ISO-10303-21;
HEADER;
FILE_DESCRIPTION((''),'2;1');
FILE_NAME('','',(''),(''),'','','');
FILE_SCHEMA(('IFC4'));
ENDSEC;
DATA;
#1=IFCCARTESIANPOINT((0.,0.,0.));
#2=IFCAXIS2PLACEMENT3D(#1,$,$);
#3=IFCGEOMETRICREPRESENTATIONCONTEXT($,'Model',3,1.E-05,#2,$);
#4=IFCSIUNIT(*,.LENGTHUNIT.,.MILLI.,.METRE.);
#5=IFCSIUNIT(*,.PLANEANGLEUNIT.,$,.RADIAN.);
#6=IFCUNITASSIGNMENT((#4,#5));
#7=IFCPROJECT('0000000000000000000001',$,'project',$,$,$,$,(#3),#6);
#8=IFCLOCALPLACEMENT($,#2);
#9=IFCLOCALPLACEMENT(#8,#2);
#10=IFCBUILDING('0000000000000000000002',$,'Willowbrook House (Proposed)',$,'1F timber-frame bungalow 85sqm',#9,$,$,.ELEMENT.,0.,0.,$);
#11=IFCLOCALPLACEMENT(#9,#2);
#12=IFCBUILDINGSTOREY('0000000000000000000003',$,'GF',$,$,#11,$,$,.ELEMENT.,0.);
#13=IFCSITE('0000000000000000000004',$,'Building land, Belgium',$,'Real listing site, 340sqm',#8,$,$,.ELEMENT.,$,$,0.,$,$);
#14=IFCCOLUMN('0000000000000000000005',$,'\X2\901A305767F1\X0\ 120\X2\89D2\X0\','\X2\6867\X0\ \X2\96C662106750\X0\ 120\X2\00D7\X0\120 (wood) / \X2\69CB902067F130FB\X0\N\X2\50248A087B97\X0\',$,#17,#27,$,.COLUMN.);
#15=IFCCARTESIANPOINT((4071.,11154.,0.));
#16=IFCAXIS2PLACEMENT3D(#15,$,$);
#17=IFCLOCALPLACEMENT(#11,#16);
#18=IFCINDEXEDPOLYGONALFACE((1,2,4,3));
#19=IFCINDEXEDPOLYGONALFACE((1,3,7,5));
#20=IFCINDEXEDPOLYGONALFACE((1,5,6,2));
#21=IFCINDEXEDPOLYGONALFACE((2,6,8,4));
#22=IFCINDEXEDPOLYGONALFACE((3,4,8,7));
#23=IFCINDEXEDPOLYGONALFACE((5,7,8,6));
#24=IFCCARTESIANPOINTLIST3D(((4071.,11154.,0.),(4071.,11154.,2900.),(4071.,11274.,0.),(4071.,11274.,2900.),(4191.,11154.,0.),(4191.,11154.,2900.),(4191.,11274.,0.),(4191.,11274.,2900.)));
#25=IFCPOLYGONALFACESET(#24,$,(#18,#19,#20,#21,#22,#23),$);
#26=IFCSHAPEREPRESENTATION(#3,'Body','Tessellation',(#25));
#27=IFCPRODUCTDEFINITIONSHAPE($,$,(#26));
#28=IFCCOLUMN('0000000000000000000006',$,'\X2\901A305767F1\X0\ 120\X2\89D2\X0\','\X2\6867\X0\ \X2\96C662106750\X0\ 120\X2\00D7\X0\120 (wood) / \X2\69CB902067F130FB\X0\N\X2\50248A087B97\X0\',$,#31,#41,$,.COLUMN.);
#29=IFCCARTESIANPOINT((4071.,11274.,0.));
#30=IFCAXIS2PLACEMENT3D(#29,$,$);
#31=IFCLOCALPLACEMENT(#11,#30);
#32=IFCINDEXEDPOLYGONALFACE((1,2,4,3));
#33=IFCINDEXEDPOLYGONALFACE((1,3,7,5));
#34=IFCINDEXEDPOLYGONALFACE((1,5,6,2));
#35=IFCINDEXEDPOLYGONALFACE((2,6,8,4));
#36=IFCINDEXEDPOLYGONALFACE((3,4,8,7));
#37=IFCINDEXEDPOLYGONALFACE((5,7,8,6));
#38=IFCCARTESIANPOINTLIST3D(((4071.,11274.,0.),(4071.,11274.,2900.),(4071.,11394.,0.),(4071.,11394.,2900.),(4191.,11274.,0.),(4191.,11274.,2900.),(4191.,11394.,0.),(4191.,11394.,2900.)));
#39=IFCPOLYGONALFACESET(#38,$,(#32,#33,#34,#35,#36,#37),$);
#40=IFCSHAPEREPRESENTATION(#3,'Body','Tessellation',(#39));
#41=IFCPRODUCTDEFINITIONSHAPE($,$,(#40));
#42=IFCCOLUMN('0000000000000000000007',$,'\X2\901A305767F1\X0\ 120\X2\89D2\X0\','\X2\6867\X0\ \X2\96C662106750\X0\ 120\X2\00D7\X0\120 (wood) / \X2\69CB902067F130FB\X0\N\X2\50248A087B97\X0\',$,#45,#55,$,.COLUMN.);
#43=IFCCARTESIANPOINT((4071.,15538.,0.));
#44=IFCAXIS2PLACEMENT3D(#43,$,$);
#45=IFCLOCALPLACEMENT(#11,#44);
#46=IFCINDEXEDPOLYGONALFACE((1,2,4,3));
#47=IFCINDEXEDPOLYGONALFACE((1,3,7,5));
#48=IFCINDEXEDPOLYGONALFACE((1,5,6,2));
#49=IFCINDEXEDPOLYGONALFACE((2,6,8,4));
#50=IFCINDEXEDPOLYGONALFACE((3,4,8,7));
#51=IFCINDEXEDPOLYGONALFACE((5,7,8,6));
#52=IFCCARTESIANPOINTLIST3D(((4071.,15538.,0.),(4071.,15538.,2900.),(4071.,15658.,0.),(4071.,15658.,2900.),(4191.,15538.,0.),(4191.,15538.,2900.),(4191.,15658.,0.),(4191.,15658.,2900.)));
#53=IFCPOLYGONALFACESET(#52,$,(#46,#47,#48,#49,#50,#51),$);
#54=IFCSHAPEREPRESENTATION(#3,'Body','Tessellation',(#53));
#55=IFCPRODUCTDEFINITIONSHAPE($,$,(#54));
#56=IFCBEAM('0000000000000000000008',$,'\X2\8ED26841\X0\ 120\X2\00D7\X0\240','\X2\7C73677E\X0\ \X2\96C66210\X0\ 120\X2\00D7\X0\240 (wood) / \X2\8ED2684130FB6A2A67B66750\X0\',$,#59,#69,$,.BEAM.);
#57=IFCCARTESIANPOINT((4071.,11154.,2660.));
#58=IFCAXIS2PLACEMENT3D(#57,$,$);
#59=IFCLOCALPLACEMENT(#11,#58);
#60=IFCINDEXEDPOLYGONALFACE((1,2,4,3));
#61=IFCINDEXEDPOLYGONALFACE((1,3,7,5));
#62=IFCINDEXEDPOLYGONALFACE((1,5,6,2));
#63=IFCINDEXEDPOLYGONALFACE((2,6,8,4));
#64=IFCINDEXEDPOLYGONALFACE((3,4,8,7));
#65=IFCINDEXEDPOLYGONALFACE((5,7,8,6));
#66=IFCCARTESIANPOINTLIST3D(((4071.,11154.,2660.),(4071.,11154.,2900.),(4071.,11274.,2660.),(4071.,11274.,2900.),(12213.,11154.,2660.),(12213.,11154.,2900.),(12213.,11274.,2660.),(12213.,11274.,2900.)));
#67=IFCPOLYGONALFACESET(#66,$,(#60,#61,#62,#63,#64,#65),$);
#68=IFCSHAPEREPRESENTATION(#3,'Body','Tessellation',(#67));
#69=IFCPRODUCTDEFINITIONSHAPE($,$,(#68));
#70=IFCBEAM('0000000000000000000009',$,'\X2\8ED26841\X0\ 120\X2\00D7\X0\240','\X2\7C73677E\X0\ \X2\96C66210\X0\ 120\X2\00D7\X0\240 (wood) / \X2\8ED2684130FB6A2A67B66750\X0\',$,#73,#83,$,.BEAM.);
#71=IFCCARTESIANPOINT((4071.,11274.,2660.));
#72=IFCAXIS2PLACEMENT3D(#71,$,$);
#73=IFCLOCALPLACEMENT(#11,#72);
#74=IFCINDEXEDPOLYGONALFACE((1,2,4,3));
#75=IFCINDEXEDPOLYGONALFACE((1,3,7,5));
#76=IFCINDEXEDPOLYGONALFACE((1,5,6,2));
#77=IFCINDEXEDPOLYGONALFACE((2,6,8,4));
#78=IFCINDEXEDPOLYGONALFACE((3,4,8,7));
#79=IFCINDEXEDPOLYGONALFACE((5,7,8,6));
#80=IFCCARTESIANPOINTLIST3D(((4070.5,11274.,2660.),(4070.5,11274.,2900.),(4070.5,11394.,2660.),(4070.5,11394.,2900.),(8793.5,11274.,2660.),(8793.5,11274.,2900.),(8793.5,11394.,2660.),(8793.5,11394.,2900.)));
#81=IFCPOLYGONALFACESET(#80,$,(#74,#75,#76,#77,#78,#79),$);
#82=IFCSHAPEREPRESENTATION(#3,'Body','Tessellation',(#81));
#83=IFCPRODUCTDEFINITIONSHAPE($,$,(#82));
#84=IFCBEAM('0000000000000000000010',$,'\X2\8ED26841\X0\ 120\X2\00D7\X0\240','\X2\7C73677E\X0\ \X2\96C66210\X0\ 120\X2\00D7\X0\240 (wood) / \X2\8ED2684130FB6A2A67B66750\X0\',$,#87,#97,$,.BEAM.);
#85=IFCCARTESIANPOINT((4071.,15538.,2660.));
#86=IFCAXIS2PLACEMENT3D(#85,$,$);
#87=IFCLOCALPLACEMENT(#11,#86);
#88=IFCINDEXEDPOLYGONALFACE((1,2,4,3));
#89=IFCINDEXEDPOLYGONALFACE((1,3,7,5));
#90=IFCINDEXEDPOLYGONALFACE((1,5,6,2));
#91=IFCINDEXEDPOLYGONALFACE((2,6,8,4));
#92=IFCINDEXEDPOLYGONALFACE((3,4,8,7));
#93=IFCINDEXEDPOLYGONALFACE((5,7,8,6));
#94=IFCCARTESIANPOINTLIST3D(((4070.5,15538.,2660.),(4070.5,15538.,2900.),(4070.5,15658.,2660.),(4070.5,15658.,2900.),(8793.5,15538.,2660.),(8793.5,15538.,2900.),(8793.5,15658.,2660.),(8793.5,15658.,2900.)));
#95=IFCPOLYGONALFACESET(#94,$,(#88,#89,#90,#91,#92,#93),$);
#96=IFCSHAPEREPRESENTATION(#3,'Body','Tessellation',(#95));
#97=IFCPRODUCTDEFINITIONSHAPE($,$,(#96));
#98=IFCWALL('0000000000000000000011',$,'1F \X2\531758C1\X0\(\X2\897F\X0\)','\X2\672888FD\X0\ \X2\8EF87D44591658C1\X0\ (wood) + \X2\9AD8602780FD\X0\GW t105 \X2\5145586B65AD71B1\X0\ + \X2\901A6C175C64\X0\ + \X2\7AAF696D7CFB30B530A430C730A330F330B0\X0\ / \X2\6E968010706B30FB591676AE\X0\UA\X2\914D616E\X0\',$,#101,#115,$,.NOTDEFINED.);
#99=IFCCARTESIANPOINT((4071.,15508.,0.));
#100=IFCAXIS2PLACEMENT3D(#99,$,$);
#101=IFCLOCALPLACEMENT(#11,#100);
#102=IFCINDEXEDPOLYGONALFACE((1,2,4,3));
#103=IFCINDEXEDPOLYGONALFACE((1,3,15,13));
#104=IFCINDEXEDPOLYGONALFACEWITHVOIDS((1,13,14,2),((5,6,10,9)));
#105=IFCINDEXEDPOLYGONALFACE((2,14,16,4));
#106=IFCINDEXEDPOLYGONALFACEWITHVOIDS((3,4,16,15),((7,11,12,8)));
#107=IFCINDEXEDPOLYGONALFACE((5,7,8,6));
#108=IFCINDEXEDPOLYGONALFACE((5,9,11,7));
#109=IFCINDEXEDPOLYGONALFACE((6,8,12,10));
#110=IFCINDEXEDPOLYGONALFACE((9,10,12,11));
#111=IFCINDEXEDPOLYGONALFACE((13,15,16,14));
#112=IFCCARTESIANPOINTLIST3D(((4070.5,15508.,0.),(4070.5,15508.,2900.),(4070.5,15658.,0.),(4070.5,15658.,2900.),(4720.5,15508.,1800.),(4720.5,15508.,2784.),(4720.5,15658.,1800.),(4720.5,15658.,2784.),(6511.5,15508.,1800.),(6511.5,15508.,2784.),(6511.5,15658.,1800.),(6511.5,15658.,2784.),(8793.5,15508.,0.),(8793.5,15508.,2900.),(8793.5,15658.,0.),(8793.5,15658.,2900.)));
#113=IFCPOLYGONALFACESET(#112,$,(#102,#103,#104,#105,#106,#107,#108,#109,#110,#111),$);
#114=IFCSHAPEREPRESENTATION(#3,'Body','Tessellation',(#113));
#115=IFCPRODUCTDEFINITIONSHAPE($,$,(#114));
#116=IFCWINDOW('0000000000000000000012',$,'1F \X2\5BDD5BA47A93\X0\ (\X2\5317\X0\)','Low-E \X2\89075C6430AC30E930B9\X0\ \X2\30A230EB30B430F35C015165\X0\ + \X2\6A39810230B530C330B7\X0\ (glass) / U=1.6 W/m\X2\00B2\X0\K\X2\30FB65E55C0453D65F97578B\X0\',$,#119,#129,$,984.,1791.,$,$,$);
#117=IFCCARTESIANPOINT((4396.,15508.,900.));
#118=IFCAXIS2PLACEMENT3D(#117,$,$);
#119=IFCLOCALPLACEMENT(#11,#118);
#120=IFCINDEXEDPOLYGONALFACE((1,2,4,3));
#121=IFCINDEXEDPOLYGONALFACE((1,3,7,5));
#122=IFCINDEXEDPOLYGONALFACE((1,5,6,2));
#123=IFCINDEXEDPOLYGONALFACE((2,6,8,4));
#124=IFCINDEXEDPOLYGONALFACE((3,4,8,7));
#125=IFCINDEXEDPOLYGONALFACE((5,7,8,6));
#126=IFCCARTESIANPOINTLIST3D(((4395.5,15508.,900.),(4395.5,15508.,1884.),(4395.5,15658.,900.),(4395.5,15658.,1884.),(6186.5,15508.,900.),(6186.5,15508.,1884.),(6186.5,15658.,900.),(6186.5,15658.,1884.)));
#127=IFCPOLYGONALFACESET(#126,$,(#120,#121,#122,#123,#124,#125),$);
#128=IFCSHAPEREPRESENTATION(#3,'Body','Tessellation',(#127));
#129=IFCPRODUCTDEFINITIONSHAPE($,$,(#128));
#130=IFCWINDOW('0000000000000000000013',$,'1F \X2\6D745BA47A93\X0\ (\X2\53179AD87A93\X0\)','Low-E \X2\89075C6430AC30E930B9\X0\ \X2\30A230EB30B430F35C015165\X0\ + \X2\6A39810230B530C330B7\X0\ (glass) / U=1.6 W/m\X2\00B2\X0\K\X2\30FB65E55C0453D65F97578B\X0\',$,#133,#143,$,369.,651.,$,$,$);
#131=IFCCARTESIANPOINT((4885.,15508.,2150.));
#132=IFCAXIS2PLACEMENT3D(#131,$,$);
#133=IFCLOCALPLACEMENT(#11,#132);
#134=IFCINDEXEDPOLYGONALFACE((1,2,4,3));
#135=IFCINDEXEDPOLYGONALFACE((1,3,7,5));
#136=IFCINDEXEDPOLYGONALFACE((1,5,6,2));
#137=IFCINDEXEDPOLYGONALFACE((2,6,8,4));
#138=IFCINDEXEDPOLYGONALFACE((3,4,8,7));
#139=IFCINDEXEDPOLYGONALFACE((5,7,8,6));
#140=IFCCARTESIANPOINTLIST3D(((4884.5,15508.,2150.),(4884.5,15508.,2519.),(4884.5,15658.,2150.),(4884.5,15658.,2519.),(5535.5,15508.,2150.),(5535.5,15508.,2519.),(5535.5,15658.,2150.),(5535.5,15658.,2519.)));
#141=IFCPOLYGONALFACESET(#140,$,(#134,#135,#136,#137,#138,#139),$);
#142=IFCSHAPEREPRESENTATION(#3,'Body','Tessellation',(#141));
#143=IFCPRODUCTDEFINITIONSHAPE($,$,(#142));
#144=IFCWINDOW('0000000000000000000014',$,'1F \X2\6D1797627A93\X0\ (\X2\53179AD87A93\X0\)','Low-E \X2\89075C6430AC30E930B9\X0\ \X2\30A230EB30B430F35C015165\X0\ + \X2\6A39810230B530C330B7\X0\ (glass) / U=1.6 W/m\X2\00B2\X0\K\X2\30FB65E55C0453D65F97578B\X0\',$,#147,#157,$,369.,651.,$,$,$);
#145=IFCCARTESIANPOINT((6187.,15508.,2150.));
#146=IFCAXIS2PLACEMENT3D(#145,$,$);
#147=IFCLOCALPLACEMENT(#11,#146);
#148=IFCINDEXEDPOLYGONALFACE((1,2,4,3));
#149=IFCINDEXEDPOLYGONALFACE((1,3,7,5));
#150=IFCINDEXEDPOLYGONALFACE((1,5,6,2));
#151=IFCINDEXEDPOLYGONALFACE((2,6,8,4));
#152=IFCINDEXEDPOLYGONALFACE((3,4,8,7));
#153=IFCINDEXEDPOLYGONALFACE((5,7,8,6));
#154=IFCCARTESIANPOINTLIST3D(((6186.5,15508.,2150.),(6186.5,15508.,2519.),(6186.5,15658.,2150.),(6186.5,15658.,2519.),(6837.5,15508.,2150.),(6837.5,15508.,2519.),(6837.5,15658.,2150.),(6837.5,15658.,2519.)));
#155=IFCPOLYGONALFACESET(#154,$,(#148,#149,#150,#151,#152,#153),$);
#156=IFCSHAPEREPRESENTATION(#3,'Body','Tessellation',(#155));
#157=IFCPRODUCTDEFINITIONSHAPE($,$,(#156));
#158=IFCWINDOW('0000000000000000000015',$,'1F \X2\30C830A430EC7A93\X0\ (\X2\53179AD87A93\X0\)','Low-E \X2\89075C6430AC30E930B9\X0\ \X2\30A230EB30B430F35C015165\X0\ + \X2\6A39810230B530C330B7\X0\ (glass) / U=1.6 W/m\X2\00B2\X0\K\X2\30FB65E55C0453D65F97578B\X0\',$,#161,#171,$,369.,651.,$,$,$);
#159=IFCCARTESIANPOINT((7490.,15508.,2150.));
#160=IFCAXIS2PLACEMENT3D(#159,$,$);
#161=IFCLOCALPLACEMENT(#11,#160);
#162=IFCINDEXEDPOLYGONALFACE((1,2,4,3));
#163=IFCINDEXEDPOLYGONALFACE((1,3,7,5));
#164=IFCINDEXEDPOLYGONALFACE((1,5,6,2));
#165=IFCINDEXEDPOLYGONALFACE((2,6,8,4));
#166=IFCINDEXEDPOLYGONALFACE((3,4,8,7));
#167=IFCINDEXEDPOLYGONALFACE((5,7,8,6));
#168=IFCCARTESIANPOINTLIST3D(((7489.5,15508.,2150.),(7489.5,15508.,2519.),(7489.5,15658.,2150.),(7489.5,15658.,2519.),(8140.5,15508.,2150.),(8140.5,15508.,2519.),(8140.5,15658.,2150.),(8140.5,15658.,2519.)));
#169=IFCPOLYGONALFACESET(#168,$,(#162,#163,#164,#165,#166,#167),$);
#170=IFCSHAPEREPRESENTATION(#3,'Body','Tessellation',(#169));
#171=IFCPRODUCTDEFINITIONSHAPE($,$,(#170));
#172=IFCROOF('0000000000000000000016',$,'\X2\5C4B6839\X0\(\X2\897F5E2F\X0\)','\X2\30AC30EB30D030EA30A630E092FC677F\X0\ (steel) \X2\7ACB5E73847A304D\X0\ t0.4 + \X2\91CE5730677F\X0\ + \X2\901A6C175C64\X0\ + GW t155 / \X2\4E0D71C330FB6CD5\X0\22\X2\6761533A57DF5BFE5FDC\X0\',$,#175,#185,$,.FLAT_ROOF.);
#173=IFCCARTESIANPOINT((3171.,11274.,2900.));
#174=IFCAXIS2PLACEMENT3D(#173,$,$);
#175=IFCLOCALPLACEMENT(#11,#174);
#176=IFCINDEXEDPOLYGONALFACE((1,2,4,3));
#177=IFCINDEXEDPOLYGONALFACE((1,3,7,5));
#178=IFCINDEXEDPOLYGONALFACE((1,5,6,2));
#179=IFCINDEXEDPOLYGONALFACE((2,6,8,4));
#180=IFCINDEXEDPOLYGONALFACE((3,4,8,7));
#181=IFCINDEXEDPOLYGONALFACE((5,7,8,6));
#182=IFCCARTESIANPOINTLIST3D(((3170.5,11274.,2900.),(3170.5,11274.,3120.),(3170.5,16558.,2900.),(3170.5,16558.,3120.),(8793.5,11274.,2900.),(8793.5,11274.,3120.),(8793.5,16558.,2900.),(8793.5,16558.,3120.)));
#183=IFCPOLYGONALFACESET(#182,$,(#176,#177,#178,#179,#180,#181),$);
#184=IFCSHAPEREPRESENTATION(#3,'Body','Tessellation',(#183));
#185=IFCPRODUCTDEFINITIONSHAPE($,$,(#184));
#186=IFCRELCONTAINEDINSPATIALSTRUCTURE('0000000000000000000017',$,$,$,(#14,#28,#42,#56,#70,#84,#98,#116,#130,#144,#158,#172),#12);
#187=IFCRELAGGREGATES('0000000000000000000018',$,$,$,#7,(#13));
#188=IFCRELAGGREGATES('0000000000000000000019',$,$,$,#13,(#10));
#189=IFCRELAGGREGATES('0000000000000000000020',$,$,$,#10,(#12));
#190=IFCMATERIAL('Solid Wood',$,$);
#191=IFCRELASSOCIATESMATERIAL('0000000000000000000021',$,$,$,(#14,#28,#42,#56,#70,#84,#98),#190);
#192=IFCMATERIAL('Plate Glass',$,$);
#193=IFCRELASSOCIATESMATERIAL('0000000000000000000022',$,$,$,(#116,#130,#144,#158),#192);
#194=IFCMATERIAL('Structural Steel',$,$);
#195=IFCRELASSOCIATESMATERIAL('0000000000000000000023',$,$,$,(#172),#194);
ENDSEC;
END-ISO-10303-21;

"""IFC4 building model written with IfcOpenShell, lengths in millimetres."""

from ifc_helpers import new_model, si_unit, frame, frame_2d, origin, place, context, project, spatial, rectangle, extrude, material, element, fill, save


model = new_model("IFC4")

# Units and contexts
model_context = context("Model", 3, precision=1e-05, world=origin())
ifc_project = project(units=[si_unit("LENGTHUNIT", "METRE", prefix="MILLI"), si_unit("PLANEANGLEUNIT", "RADIAN")], contexts=[model_context])

# Site, building, storey
site_placement = place(None, origin())
site = spatial("IfcSite", under=ifc_project, at=site_placement, Name="Building land, Belgium", ObjectType="Real listing site, 340sqm", CompositionType="ELEMENT", RefElevation=0.0)
building_placement = place(site_placement, origin())
building = spatial("IfcBuilding", under=site, at=building_placement, Name="Willowbrook House (Proposed)", ObjectType="1F timber-frame bungalow 85sqm", CompositionType="ELEMENT", ElevationOfRefHeight=0.0, ElevationOfTerrain=0.0)
storey_placement = place(building_placement, origin())
storey = spatial("IfcBuildingStorey", under=building, at=storey_placement, Name="GF", CompositionType="ELEMENT", Elevation=0.0)

# Columns
ifc_material_1 = material(Name="Solid Wood")
column_1_placement = place(storey_placement, frame((4071.0, 11154.0, 0.0)))
element("IfcColumn", 1, at=column_1_placement, inside=storey, material=ifc_material_1, Name="通し柱 120角", Description="桧 集成材 120×120 (wood) / 構造柱・N値計算", PredefinedType="COLUMN", context=model_context, shape_type="SweptSolid", body=[
    extrude(rectangle(XDim=120.0, YDim=120.0, at=frame_2d((60.0, 60.0))), frame((4071.0, 11154.0, 0.0)), (0.0, 0.0, 1.0), 2900.0),
])
column_2_placement = place(storey_placement, frame((4071.0, 11274.0, 0.0)))
element("IfcColumn", 2, at=column_2_placement, inside=storey, material=ifc_material_1, Name="通し柱 120角", Description="桧 集成材 120×120 (wood) / 構造柱・N値計算", PredefinedType="COLUMN", context=model_context, shape_type="SweptSolid", body=[
    extrude(rectangle(XDim=120.0, YDim=120.0, at=frame_2d((60.0, 60.0))), frame((4071.0, 11274.0, 0.0)), (0.0, 0.0, 1.0), 2900.0),
])
column_3_placement = place(storey_placement, frame((4071.0, 15538.0, 0.0)))
element("IfcColumn", 3, at=column_3_placement, inside=storey, material=ifc_material_1, Name="通し柱 120角", Description="桧 集成材 120×120 (wood) / 構造柱・N値計算", PredefinedType="COLUMN", context=model_context, shape_type="SweptSolid", body=[
    extrude(rectangle(XDim=120.0, YDim=120.0, at=frame_2d((60.0, 60.0))), frame((4071.0, 15538.0, 0.0)), (0.0, 0.0, 1.0), 2900.0),
])

# Beams
beam_1_placement = place(storey_placement, frame((4071.0, 11154.0, 2660.0)))
element("IfcBeam", 4, at=beam_1_placement, inside=storey, material=ifc_material_1, Name="軒桁 120×240", Description="米松 集成 120×240 (wood) / 軒桁・横架材", PredefinedType="BEAM", context=model_context, shape_type="SweptSolid", body=[
    extrude(rectangle(XDim=8142.0, YDim=120.0, at=frame_2d((4071.0, 60.0))), frame((4071.0, 11154.0, 2660.0)), (0.0, 0.0, 1.0), 240.0),
])
beam_2_placement = place(storey_placement, frame((4071.0, 11274.0, 2660.0)))
element("IfcBeam", 5, at=beam_2_placement, inside=storey, material=ifc_material_1, Name="軒桁 120×240", Description="米松 集成 120×240 (wood) / 軒桁・横架材", PredefinedType="BEAM", context=model_context, shape_type="SweptSolid", body=[
    extrude(rectangle(XDim=4723.0, YDim=120.0, at=frame_2d((2361.0, 60.0))), frame((4071.0, 11274.0, 2660.0)), (0.0, 0.0, 1.0), 240.0),
])
beam_3_placement = place(storey_placement, frame((4071.0, 15538.0, 2660.0)))
element("IfcBeam", 6, at=beam_3_placement, inside=storey, material=ifc_material_1, Name="軒桁 120×240", Description="米松 集成 120×240 (wood) / 軒桁・横架材", PredefinedType="BEAM", context=model_context, shape_type="SweptSolid", body=[
    extrude(rectangle(XDim=4723.0, YDim=120.0, at=frame_2d((2361.0, 60.0))), frame((4071.0, 15538.0, 2660.0)), (0.0, 0.0, 1.0), 240.0),
])

# Wall, openings, windows
wall_1_placement = place(storey_placement, frame((4071.0, 15508.0, 0.0)))
wall_1 = element("IfcWall", 7, at=wall_1_placement, inside=storey, material=ifc_material_1, Name="1F 北壁(西)", Description="木製 軸組外壁 (wood) + 高性能GW t105 充填断熱 + 通気層 + 窯業系サイディング / 準耐火・外皮UA配慮", PredefinedType="NOTDEFINED", context=model_context, shape_type="SweptSolid", body=[
    extrude(rectangle(XDim=4723.0, YDim=150.0, at=frame_2d((2361.0, 75.0))), frame((4071.0, 15508.0, 0.0)), (0.0, 0.0, 1.0), 2900.0),
])
opening_1_placement = place(storey_placement, frame((4396.0, 15508.0, 900.0)))
opening_1 = element("IfcOpeningElement", 8, at=opening_1_placement, cuts=wall_1, PredefinedType="NOTDEFINED", context=model_context, shape_type="SweptSolid", body=[
    extrude(rectangle(XDim=1791.0, YDim=150.0, at=frame_2d((895.0, 75.0))), frame((4396.0, 15508.0, 900.0)), (0.0, 0.0, 1.0), 984.0),
])
opening_2_placement = place(storey_placement, frame((4885.0, 15508.0, 2150.0)))
opening_2 = element("IfcOpeningElement", 9, at=opening_2_placement, cuts=wall_1, PredefinedType="NOTDEFINED", context=model_context, shape_type="SweptSolid", body=[
    extrude(rectangle(XDim=651.0, YDim=150.0, at=frame_2d((325.0, 75.0))), frame((4885.0, 15508.0, 2150.0)), (0.0, 0.0, 1.0), 369.0),
])
opening_3_placement = place(storey_placement, frame((6187.0, 15508.0, 2150.0)))
opening_3 = element("IfcOpeningElement", 10, at=opening_3_placement, cuts=wall_1, PredefinedType="NOTDEFINED", context=model_context, shape_type="SweptSolid", body=[
    extrude(rectangle(XDim=651.0, YDim=150.0, at=frame_2d((325.0, 75.0))), frame((6187.0, 15508.0, 2150.0)), (0.0, 0.0, 1.0), 369.0),
])
opening_4_placement = place(storey_placement, frame((7490.0, 15508.0, 2150.0)))
opening_4 = element("IfcOpeningElement", 11, at=opening_4_placement, cuts=wall_1, PredefinedType="NOTDEFINED", context=model_context, shape_type="SweptSolid", body=[
    extrude(rectangle(XDim=651.0, YDim=150.0, at=frame_2d((325.0, 75.0))), frame((7490.0, 15508.0, 2150.0)), (0.0, 0.0, 1.0), 369.0),
])
ifc_material_2 = material(Name="Plate Glass")
window_1_placement = place(storey_placement, frame((4396.0, 15508.0, 900.0)))
window_1 = element("IfcWindow", 12, at=window_1_placement, inside=storey, material=ifc_material_2, Name="1F 寝室窓 (北)", Description="Low-E 複層ガラス アルゴン封入 + 樹脂サッシ (glass) / U=1.6 W/m²K・日射取得型", OverallHeight=984.0, OverallWidth=1791.0, context=model_context, shape_type="SweptSolid", body=[
    extrude(rectangle(XDim=1791.0, YDim=150.0, at=frame_2d((895.0, 75.0))), frame((4396.0, 15508.0, 900.0)), (0.0, 0.0, 1.0), 984.0),
])
fill(opening_1, window_1)
window_2_placement = place(storey_placement, frame((4885.0, 15508.0, 2150.0)))
window_2 = element("IfcWindow", 13, at=window_2_placement, inside=storey, material=ifc_material_2, Name="1F 浴室窓 (北高窓)", Description="Low-E 複層ガラス アルゴン封入 + 樹脂サッシ (glass) / U=1.6 W/m²K・日射取得型", OverallHeight=369.0, OverallWidth=651.0, context=model_context, shape_type="SweptSolid", body=[
    extrude(rectangle(XDim=651.0, YDim=150.0, at=frame_2d((325.0, 75.0))), frame((4885.0, 15508.0, 2150.0)), (0.0, 0.0, 1.0), 369.0),
])
fill(opening_2, window_2)
window_3_placement = place(storey_placement, frame((6187.0, 15508.0, 2150.0)))
window_3 = element("IfcWindow", 14, at=window_3_placement, inside=storey, material=ifc_material_2, Name="1F 洗面窓 (北高窓)", Description="Low-E 複層ガラス アルゴン封入 + 樹脂サッシ (glass) / U=1.6 W/m²K・日射取得型", OverallHeight=369.0, OverallWidth=651.0, context=model_context, shape_type="SweptSolid", body=[
    extrude(rectangle(XDim=651.0, YDim=150.0, at=frame_2d((325.0, 75.0))), frame((6187.0, 15508.0, 2150.0)), (0.0, 0.0, 1.0), 369.0),
])
fill(opening_3, window_3)
window_4_placement = place(storey_placement, frame((7490.0, 15508.0, 2150.0)))
window_4 = element("IfcWindow", 15, at=window_4_placement, inside=storey, material=ifc_material_2, Name="1F トイレ窓 (北高窓)", Description="Low-E 複層ガラス アルゴン封入 + 樹脂サッシ (glass) / U=1.6 W/m²K・日射取得型", OverallHeight=369.0, OverallWidth=651.0, context=model_context, shape_type="SweptSolid", body=[
    extrude(rectangle(XDim=651.0, YDim=150.0, at=frame_2d((325.0, 75.0))), frame((7490.0, 15508.0, 2150.0)), (0.0, 0.0, 1.0), 369.0),
])
fill(opening_4, window_4)

# Roof
ifc_material_3 = material(Name="Structural Steel")
roof_placement = place(storey_placement, frame((3171.0, 11274.0, 2900.0)))
element("IfcRoof", 16, at=roof_placement, inside=storey, material=ifc_material_3, Name="屋根(西帯)", Description="ガルバリウム鋼板 (steel) 立平葺き t0.4 + 野地板 + 通気層 + GW t155 / 不燃・法22条区域対応", PredefinedType="FLAT_ROOF", context=model_context, shape_type="SweptSolid", body=[
    extrude(rectangle(XDim=5623.0, YDim=5284.0, at=frame_2d((2811.0, 2642.0))), frame((3171.0, 11274.0, 2900.0)), (0.0, 0.0, 1.0), 220.0),
])

save(model, "model.ifc")
